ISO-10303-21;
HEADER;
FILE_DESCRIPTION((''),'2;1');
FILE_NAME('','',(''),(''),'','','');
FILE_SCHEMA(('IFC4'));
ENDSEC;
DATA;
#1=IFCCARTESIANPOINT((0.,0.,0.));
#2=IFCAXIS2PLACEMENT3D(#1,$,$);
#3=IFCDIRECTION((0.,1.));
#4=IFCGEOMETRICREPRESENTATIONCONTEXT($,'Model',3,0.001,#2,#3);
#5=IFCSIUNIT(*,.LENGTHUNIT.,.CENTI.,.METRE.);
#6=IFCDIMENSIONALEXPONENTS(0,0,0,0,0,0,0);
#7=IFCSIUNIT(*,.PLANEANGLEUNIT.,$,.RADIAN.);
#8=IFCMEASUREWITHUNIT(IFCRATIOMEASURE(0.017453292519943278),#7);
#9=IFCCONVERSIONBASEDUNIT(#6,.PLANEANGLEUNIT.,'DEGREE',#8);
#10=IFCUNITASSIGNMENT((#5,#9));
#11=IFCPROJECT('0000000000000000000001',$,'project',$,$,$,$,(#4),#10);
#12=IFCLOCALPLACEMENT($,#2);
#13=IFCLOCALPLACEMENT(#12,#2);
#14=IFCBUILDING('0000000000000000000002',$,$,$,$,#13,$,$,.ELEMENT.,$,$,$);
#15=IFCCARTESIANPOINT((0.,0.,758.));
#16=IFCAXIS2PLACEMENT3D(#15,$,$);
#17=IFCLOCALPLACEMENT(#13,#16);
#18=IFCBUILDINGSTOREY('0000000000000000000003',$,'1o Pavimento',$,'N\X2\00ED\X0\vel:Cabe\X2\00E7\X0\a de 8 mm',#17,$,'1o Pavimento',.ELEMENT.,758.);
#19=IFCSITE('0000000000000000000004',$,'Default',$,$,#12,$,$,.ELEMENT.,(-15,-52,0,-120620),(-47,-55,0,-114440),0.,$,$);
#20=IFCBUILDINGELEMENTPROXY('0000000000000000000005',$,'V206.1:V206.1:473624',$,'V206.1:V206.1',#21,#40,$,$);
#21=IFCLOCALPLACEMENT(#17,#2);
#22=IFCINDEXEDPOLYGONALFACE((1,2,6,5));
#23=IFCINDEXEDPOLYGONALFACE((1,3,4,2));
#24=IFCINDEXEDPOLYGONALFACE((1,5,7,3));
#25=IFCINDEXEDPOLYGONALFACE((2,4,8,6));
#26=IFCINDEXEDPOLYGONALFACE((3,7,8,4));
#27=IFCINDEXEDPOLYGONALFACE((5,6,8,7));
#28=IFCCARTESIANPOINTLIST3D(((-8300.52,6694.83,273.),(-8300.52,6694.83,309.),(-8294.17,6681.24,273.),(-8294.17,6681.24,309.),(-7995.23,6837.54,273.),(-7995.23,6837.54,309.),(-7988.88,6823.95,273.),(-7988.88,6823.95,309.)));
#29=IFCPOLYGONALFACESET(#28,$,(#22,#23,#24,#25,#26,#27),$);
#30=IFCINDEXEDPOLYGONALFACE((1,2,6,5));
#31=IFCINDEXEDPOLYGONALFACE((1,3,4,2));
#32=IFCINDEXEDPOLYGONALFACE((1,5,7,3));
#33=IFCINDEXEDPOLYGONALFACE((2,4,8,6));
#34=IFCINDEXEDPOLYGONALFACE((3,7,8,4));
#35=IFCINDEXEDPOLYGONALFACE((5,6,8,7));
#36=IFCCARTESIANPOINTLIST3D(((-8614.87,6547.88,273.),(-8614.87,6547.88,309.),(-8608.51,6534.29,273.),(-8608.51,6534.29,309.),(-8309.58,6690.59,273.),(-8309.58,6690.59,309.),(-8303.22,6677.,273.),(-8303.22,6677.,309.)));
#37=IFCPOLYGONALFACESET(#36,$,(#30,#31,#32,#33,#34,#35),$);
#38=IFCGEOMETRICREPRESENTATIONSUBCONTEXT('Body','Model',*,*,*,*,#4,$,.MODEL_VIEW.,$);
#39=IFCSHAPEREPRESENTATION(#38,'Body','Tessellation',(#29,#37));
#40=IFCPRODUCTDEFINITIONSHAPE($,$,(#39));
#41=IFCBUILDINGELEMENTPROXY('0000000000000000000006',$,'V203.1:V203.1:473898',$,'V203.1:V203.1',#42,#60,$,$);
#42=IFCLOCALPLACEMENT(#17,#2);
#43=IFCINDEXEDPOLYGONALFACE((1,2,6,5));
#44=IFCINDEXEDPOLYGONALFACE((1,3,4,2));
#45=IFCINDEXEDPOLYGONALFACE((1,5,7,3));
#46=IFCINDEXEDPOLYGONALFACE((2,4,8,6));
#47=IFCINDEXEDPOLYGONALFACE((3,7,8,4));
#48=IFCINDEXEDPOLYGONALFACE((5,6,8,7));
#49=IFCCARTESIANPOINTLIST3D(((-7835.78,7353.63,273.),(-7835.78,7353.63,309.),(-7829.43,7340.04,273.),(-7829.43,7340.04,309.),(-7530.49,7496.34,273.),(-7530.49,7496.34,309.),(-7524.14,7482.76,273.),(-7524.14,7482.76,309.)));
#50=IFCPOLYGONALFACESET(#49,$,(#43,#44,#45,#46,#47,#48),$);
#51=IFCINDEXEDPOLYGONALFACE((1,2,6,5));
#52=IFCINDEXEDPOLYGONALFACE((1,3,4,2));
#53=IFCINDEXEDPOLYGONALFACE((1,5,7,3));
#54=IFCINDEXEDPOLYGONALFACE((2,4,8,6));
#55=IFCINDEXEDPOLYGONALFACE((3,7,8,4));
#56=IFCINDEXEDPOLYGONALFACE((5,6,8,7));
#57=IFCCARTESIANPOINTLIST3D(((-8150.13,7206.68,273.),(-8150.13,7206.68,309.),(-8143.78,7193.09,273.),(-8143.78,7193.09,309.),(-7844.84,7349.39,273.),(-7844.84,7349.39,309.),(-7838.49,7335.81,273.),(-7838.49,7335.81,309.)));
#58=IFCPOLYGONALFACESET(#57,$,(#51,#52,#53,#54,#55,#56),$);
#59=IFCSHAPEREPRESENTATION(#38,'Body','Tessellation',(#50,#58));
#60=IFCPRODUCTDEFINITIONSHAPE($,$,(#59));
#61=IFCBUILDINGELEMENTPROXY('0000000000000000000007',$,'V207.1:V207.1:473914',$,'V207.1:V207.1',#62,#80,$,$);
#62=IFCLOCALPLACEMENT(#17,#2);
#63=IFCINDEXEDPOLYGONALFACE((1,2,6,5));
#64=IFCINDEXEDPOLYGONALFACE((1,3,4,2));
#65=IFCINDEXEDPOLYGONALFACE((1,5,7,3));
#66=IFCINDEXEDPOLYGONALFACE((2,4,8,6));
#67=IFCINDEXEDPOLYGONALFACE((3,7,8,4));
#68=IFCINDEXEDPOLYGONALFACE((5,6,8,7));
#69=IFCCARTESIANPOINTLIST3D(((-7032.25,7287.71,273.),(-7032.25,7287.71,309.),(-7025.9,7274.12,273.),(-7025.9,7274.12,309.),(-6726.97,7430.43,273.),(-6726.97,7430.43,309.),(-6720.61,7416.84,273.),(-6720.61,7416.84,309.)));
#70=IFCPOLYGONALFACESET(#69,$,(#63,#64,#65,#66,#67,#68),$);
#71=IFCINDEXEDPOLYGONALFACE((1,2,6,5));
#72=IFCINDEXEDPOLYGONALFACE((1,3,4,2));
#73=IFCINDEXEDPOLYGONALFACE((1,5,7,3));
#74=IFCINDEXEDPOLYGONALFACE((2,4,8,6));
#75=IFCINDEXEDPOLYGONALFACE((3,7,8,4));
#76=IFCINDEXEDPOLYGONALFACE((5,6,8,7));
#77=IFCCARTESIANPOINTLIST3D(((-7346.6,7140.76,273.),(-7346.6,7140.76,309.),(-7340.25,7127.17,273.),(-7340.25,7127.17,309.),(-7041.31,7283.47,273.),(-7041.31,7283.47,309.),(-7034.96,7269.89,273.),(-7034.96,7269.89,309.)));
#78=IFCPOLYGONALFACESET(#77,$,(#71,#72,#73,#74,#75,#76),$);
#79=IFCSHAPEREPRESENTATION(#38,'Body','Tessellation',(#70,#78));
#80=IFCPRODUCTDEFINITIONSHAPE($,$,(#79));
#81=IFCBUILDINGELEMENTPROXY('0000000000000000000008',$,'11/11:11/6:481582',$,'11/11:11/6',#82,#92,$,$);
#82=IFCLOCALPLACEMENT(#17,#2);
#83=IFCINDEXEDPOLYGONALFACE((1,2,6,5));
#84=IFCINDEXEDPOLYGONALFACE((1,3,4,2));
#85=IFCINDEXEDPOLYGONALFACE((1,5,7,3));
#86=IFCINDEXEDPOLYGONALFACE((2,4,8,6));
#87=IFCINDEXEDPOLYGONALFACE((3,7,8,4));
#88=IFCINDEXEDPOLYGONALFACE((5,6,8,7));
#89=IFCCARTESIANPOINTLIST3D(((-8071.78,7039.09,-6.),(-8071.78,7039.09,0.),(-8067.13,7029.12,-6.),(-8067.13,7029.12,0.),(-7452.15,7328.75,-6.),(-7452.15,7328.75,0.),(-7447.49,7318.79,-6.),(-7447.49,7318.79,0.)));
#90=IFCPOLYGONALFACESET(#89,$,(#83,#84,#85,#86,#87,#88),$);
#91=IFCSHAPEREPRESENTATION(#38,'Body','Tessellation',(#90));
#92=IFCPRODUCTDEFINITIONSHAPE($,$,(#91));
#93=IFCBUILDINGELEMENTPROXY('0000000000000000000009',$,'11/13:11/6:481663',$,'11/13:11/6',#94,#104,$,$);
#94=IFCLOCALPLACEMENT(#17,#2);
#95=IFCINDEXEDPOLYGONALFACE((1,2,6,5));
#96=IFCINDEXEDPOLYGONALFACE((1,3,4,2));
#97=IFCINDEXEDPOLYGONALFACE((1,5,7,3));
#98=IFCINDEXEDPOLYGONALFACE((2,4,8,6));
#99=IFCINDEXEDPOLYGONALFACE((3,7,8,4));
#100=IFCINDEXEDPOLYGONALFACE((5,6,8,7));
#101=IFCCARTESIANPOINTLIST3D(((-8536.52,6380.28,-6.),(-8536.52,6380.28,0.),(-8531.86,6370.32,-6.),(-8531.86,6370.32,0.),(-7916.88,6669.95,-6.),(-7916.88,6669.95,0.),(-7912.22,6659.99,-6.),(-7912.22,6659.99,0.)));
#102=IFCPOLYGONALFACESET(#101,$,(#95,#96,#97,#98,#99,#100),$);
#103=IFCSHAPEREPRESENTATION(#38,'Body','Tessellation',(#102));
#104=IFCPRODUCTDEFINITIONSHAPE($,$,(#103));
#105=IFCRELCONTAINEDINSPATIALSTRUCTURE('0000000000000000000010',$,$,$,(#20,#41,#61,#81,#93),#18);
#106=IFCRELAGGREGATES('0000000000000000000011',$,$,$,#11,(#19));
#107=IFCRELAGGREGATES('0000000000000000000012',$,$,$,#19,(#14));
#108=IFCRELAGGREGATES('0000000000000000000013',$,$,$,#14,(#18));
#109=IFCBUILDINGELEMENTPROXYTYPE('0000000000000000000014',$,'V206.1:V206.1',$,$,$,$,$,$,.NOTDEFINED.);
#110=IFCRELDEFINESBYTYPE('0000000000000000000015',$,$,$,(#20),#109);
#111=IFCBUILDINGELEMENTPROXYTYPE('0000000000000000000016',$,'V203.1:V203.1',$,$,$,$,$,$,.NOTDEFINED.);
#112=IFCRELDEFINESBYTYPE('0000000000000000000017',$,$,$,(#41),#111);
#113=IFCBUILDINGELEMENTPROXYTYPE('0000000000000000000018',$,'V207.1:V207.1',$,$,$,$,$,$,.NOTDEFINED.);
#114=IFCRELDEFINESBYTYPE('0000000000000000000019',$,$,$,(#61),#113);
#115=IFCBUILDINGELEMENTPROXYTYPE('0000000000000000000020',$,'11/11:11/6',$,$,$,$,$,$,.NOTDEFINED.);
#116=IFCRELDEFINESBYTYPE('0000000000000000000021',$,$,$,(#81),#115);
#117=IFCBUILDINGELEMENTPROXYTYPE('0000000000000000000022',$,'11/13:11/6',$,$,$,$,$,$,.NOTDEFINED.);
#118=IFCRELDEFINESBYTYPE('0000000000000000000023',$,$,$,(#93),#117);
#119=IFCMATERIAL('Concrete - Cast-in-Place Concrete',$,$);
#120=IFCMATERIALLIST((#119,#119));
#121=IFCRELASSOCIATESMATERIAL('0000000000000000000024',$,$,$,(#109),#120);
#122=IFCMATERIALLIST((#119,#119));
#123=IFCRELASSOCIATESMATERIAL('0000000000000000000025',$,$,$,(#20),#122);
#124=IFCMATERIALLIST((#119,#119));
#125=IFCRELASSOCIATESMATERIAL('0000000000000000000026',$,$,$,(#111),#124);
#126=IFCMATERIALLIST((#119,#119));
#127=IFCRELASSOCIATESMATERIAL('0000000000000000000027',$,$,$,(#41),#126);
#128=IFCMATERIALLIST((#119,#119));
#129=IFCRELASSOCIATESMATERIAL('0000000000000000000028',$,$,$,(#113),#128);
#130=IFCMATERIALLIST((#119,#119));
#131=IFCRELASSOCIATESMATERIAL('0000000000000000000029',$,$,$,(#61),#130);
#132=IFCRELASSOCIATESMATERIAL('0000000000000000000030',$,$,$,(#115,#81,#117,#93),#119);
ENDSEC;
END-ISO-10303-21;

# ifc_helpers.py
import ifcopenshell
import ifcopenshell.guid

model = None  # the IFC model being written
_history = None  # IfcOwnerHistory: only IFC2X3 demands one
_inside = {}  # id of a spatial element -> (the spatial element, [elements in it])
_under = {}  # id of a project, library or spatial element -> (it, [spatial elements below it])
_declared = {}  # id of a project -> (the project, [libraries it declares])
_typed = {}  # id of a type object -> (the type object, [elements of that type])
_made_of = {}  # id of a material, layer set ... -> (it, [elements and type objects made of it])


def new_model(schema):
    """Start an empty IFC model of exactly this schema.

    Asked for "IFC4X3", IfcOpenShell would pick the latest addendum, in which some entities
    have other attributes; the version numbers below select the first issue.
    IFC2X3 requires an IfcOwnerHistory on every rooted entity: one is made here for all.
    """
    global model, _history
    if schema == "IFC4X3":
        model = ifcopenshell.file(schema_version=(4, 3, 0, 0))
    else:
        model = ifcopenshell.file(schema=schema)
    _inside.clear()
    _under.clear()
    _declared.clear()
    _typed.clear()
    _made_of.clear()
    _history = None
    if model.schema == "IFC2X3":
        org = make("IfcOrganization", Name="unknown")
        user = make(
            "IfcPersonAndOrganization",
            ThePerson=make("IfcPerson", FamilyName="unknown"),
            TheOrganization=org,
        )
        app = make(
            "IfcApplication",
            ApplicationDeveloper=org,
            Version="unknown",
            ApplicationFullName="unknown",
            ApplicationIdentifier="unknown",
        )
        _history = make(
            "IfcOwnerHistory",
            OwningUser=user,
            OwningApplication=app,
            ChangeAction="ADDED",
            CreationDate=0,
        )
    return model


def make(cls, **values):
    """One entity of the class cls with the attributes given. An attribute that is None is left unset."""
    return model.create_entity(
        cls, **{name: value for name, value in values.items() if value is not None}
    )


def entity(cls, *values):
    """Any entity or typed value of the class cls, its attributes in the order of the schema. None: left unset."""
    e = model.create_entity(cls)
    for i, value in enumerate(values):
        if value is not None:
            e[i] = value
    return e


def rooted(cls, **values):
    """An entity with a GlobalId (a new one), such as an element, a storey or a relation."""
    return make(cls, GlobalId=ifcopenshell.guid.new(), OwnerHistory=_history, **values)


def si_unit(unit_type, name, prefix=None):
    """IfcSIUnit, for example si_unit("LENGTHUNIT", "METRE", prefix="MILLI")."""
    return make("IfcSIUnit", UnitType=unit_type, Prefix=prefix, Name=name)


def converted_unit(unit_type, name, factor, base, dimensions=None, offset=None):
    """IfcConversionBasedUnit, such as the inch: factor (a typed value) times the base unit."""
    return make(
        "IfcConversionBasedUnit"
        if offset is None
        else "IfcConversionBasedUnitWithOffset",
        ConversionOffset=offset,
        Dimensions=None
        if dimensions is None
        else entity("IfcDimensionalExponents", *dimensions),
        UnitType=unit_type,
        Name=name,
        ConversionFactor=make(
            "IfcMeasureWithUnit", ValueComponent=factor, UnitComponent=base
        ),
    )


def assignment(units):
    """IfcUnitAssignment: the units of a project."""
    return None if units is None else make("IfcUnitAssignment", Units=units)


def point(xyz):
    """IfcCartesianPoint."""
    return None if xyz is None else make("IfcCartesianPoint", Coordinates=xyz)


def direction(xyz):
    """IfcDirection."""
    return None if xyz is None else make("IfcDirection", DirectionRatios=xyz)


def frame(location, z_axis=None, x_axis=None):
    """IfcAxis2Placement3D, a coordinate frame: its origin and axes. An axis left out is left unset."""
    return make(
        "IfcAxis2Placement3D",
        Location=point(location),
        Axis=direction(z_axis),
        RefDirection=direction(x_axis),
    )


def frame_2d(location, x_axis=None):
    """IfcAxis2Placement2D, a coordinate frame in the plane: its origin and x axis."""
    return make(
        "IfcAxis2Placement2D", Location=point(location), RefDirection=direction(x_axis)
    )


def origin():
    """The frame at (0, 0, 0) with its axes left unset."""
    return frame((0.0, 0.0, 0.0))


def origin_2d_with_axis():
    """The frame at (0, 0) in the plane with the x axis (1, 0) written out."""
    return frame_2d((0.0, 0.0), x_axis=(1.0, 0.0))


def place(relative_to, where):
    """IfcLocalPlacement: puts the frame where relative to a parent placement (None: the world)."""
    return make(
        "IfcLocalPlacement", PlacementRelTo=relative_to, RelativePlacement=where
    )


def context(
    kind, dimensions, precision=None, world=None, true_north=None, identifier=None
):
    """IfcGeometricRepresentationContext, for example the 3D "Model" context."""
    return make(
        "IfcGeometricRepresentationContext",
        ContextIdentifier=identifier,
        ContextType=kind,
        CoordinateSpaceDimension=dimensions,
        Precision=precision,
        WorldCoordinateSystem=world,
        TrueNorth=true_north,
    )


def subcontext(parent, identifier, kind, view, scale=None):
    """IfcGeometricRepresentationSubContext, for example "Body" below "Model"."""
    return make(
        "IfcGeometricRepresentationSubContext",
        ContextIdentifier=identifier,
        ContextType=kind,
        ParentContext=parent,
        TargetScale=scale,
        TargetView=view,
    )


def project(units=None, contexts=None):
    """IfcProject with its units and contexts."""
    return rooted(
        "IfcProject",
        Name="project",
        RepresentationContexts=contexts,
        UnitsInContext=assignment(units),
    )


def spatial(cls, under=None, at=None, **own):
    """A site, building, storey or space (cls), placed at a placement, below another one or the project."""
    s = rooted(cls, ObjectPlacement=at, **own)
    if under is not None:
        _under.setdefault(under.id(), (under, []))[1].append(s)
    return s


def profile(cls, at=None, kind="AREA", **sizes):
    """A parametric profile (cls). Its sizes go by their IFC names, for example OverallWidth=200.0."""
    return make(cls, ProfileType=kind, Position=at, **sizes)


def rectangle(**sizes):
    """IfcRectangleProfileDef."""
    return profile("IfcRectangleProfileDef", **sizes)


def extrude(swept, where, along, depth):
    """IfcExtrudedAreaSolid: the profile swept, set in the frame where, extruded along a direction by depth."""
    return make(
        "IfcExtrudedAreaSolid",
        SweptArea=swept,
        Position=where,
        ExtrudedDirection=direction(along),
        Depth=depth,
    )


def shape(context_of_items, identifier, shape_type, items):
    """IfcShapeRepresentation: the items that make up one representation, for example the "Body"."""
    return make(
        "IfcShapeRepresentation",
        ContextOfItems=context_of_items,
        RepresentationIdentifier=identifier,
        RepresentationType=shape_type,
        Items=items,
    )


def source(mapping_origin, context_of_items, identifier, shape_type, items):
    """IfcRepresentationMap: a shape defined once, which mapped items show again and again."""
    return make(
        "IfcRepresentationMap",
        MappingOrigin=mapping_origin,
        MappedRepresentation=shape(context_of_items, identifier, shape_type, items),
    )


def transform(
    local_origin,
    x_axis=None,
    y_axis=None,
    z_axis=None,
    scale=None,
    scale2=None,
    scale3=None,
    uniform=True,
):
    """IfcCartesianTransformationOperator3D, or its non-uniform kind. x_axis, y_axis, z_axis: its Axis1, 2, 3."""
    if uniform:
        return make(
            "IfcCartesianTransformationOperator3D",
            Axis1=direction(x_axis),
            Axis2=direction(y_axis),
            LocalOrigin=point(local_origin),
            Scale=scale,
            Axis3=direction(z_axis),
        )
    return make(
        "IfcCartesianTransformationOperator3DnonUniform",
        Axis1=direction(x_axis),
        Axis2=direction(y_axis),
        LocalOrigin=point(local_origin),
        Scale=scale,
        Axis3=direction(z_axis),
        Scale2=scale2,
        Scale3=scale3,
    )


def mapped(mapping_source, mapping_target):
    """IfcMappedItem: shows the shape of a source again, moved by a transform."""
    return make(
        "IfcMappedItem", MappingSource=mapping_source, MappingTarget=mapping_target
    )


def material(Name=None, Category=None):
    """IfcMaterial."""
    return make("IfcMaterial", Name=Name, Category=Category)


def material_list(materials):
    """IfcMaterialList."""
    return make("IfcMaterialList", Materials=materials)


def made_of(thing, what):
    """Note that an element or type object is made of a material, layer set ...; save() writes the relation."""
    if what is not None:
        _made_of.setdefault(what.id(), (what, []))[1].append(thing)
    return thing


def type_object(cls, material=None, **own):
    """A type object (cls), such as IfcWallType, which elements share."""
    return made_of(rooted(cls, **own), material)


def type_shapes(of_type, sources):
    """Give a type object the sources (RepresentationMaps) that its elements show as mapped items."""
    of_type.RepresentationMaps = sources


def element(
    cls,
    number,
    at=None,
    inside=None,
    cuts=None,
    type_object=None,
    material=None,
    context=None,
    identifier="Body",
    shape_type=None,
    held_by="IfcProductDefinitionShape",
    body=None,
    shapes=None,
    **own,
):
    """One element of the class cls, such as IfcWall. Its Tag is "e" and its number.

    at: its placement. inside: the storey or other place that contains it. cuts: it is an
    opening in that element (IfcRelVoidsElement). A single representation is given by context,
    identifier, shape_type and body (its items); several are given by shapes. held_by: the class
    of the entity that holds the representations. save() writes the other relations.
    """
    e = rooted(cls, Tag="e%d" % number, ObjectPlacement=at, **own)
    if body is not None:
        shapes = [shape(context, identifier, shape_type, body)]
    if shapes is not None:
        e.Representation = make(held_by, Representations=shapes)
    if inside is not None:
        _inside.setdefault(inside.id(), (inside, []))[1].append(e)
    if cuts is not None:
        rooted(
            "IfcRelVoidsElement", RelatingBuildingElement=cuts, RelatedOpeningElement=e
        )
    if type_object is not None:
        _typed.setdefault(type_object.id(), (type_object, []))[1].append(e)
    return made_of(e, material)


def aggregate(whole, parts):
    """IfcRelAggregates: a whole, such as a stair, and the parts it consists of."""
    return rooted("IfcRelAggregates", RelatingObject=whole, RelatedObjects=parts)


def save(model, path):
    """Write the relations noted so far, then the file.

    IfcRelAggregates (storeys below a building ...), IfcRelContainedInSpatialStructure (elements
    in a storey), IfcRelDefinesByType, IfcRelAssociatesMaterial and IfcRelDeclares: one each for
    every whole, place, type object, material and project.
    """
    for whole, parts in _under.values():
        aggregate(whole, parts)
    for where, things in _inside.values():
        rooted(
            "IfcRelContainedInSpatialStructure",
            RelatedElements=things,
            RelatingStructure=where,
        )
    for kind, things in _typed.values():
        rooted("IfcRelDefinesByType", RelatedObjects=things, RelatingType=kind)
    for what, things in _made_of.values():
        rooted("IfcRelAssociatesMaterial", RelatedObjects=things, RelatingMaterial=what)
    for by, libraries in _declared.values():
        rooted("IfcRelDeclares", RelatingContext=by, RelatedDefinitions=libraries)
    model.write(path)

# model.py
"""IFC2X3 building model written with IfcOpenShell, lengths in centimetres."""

from ifc_helpers import new_model, entity, si_unit, converted_unit, direction, frame, frame_2d, origin, origin_2d_with_axis, place, context, subcontext, project, spatial, rectangle, extrude, source, transform, mapped, material, material_list, type_object, type_shapes, element, save


model = new_model("IFC2X3")

# Units and contexts
model_context = context("Model", 3, precision=0.001, world=origin(), true_north=direction((0.0, 1.0)))
body_context = subcontext(model_context, "Body", "Model", "MODEL_VIEW")
ifc_project = project(units=[si_unit("LENGTHUNIT", "METRE", prefix="CENTI"), converted_unit("PLANEANGLEUNIT", "DEGREE", entity("IfcRatioMeasure", 0.017453292519943278), si_unit("PLANEANGLEUNIT", "RADIAN"), dimensions=[0, 0, 0, 0, 0, 0, 0])], contexts=[model_context])

# Site, building, storey
site_placement = place(None, origin())
site = spatial("IfcSite", under=ifc_project, at=site_placement, Name="Default", CompositionType="ELEMENT", RefLatitude=(-15, -52, 0, -120620), RefLongitude=(-47, -55, 0, -114440), RefElevation=0.0)
building_placement = place(site_placement, origin())
building = spatial("IfcBuilding", under=site, at=building_placement, CompositionType="ELEMENT")
storey_placement = place(building_placement, frame((0.0, 0.0, 758.0)))
storey = spatial("IfcBuildingStorey", under=building, at=storey_placement, Name="1o Pavimento", ObjectType="Nível:Cabeça de 8 mm", LongName="1o Pavimento", CompositionType="ELEMENT", Elevation=758.0)

# Building element proxies
ifc_material_1 = material(Name="Concrete - Cast-in-Place Concrete")
ifc_material_list_1 = material_list([ifc_material_1, ifc_material_1])
ifc_material_list_2 = material_list([ifc_material_1, ifc_material_1])
building_element_proxy_type_1 = type_object("IfcBuildingElementProxyType", Name="V206.1:V206.1", PredefinedType="NOTDEFINED", material=ifc_material_list_2)
shared_shape_1 = source(origin(), body_context, "Body", "SweptSolid", [
    extrude(rectangle(XDim=15.0, YDim=337.0, at=frame_2d((0.0, 0.0), x_axis=(1.0, 0.0))), frame((470.17, 225.1, 0.0), z_axis=(0.0, 0.0, 1.0), x_axis=(-0.423488, 0.905902, 0.0)), (0.0, 0.0, 1.0), 36.0),
    extrude(rectangle(XDim=337.0, YDim=15.0, at=frame_2d((0.0, 0.0), x_axis=(1.0, 0.0))), frame((155.82, 78.15, 0.0), z_axis=(0.0, 0.0, 1.0), x_axis=(-0.905902, -0.423488, 0.0)), (0.0, 0.0, 1.0), 36.0),
])
type_shapes(building_element_proxy_type_1, [shared_shape_1])
proxy_1_placement = place(storey_placement, frame((-8614.87, 6534.29, 273.0)))
element("IfcBuildingElementProxy", 1, at=proxy_1_placement, inside=storey, type_object=building_element_proxy_type_1, material=ifc_material_list_1, Name="V206.1:V206.1:473624", ObjectType="V206.1:V206.1", context=body_context, shape_type="MappedRepresentation", body=[
    mapped(shared_shape_1, transform((0.0, 0.0, 0.0), scale=1.0)),
])
ifc_material_list_3 = material_list([ifc_material_1, ifc_material_1])
ifc_material_list_4 = material_list([ifc_material_1, ifc_material_1])
building_element_proxy_type_2 = type_object("IfcBuildingElementProxyType", Name="V203.1:V203.1", PredefinedType="NOTDEFINED", material=ifc_material_list_4)
shared_shape_2 = source(origin(), body_context, "Body", "SweptSolid", [
    extrude(rectangle(XDim=15.0, YDim=337.0, at=frame_2d((0.0, 0.0), x_axis=(1.0, 0.0))), frame((470.17, 225.1, 0.0), z_axis=(0.0, 0.0, 1.0), x_axis=(-0.423488, 0.905902, 0.0)), (0.0, 0.0, 1.0), 36.0),
    extrude(rectangle(XDim=337.0, YDim=15.0, at=origin_2d_with_axis()), frame((155.82, 78.15, 0.0), z_axis=(0.0, 0.0, 1.0), x_axis=(-0.905902, -0.423488, 0.0)), (0.0, 0.0, 1.0), 36.0),
])
type_shapes(building_element_proxy_type_2, [shared_shape_2])
proxy_2_placement = place(storey_placement, frame((-8150.13, 7193.09, 273.0)))
element("IfcBuildingElementProxy", 2, at=proxy_2_placement, inside=storey, type_object=building_element_proxy_type_2, material=ifc_material_list_3, Name="V203.1:V203.1:473898", ObjectType="V203.1:V203.1", context=body_context, shape_type="MappedRepresentation", body=[
    mapped(shared_shape_2, transform((0.0, 0.0, 0.0), scale=1.0)),
])
ifc_material_list_5 = material_list([ifc_material_1, ifc_material_1])
ifc_material_list_6 = material_list([ifc_material_1, ifc_material_1])
building_element_proxy_type_3 = type_object("IfcBuildingElementProxyType", Name="V207.1:V207.1", PredefinedType="NOTDEFINED", material=ifc_material_list_6)
shared_shape_3 = source(origin(), body_context, "Body", "SweptSolid", [
    extrude(rectangle(XDim=15.0, YDim=337.0, at=frame_2d((0.0, 0.0), x_axis=(1.0, 0.0))), frame((470.17, 225.1, 0.0), z_axis=(0.0, 0.0, 1.0), x_axis=(-0.423488, 0.905902, 0.0)), (0.0, 0.0, 1.0), 36.0),
    extrude(rectangle(XDim=337.0, YDim=15.0, at=frame_2d((0.0, 0.0), x_axis=(1.0, 0.0))), frame((155.82, 78.15, 0.0), z_axis=(0.0, 0.0, 1.0), x_axis=(-0.905902, -0.423488, 0.0)), (0.0, 0.0, 1.0), 36.0),
])
type_shapes(building_element_proxy_type_3, [shared_shape_3])
proxy_3_placement = place(storey_placement, frame((-7346.6, 7127.17, 273.0)))
element("IfcBuildingElementProxy", 3, at=proxy_3_placement, inside=storey, type_object=building_element_proxy_type_3, material=ifc_material_list_5, Name="V207.1:V207.1:473914", ObjectType="V207.1:V207.1", context=body_context, shape_type="MappedRepresentation", body=[
    mapped(shared_shape_3, transform((0.0, 0.0, 0.0), scale=1.0)),
])
building_element_proxy_type_4 = type_object("IfcBuildingElementProxyType", Name="11/11:11/6", PredefinedType="NOTDEFINED", material=ifc_material_1)
shared_shape_4 = source(origin(), body_context, "Body", "SweptSolid", [
    extrude(rectangle(XDim=11.0, YDim=684.0, at=origin_2d_with_axis()), frame((312.15, 149.82, 0.0), z_axis=(0.0, 0.0, 1.0), x_axis=(0.423488, -0.905902, 0.0)), (0.0, 0.0, 1.0), 6.0),
])
type_shapes(building_element_proxy_type_4, [shared_shape_4])
proxy_4_placement = place(storey_placement, frame((-8071.78, 7029.12, -6.0)))
element("IfcBuildingElementProxy", 4, at=proxy_4_placement, inside=storey, type_object=building_element_proxy_type_4, material=ifc_material_1, Name="11/11:11/6:481582", ObjectType="11/11:11/6", context=body_context, shape_type="MappedRepresentation", body=[
    mapped(shared_shape_4, transform((0.0, 0.0, 0.0), scale=1.0)),
])
building_element_proxy_type_5 = type_object("IfcBuildingElementProxyType", Name="11/13:11/6", PredefinedType="NOTDEFINED", material=ifc_material_1)
shared_shape_5 = source(origin(), body_context, "Body", "SweptSolid", [
    extrude(rectangle(XDim=11.0, YDim=684.0, at=origin_2d_with_axis()), frame((312.15, 149.82, 0.0), z_axis=(0.0, 0.0, 1.0), x_axis=(0.423488, -0.905902, 0.0)), (0.0, 0.0, 1.0), 6.0),
])
type_shapes(building_element_proxy_type_5, [shared_shape_5])
proxy_5_placement = place(storey_placement, frame((-8536.52, 6370.32, -6.0)))
element("IfcBuildingElementProxy", 5, at=proxy_5_placement, inside=storey, type_object=building_element_proxy_type_5, material=ifc_material_1, Name="11/13:11/6:481663", ObjectType="11/13:11/6", context=body_context, shape_type="MappedRepresentation", body=[
    mapped(shared_shape_5, transform((0.0, 0.0, 0.0), scale=1.0)),
])

save(model, "model.ifc")
